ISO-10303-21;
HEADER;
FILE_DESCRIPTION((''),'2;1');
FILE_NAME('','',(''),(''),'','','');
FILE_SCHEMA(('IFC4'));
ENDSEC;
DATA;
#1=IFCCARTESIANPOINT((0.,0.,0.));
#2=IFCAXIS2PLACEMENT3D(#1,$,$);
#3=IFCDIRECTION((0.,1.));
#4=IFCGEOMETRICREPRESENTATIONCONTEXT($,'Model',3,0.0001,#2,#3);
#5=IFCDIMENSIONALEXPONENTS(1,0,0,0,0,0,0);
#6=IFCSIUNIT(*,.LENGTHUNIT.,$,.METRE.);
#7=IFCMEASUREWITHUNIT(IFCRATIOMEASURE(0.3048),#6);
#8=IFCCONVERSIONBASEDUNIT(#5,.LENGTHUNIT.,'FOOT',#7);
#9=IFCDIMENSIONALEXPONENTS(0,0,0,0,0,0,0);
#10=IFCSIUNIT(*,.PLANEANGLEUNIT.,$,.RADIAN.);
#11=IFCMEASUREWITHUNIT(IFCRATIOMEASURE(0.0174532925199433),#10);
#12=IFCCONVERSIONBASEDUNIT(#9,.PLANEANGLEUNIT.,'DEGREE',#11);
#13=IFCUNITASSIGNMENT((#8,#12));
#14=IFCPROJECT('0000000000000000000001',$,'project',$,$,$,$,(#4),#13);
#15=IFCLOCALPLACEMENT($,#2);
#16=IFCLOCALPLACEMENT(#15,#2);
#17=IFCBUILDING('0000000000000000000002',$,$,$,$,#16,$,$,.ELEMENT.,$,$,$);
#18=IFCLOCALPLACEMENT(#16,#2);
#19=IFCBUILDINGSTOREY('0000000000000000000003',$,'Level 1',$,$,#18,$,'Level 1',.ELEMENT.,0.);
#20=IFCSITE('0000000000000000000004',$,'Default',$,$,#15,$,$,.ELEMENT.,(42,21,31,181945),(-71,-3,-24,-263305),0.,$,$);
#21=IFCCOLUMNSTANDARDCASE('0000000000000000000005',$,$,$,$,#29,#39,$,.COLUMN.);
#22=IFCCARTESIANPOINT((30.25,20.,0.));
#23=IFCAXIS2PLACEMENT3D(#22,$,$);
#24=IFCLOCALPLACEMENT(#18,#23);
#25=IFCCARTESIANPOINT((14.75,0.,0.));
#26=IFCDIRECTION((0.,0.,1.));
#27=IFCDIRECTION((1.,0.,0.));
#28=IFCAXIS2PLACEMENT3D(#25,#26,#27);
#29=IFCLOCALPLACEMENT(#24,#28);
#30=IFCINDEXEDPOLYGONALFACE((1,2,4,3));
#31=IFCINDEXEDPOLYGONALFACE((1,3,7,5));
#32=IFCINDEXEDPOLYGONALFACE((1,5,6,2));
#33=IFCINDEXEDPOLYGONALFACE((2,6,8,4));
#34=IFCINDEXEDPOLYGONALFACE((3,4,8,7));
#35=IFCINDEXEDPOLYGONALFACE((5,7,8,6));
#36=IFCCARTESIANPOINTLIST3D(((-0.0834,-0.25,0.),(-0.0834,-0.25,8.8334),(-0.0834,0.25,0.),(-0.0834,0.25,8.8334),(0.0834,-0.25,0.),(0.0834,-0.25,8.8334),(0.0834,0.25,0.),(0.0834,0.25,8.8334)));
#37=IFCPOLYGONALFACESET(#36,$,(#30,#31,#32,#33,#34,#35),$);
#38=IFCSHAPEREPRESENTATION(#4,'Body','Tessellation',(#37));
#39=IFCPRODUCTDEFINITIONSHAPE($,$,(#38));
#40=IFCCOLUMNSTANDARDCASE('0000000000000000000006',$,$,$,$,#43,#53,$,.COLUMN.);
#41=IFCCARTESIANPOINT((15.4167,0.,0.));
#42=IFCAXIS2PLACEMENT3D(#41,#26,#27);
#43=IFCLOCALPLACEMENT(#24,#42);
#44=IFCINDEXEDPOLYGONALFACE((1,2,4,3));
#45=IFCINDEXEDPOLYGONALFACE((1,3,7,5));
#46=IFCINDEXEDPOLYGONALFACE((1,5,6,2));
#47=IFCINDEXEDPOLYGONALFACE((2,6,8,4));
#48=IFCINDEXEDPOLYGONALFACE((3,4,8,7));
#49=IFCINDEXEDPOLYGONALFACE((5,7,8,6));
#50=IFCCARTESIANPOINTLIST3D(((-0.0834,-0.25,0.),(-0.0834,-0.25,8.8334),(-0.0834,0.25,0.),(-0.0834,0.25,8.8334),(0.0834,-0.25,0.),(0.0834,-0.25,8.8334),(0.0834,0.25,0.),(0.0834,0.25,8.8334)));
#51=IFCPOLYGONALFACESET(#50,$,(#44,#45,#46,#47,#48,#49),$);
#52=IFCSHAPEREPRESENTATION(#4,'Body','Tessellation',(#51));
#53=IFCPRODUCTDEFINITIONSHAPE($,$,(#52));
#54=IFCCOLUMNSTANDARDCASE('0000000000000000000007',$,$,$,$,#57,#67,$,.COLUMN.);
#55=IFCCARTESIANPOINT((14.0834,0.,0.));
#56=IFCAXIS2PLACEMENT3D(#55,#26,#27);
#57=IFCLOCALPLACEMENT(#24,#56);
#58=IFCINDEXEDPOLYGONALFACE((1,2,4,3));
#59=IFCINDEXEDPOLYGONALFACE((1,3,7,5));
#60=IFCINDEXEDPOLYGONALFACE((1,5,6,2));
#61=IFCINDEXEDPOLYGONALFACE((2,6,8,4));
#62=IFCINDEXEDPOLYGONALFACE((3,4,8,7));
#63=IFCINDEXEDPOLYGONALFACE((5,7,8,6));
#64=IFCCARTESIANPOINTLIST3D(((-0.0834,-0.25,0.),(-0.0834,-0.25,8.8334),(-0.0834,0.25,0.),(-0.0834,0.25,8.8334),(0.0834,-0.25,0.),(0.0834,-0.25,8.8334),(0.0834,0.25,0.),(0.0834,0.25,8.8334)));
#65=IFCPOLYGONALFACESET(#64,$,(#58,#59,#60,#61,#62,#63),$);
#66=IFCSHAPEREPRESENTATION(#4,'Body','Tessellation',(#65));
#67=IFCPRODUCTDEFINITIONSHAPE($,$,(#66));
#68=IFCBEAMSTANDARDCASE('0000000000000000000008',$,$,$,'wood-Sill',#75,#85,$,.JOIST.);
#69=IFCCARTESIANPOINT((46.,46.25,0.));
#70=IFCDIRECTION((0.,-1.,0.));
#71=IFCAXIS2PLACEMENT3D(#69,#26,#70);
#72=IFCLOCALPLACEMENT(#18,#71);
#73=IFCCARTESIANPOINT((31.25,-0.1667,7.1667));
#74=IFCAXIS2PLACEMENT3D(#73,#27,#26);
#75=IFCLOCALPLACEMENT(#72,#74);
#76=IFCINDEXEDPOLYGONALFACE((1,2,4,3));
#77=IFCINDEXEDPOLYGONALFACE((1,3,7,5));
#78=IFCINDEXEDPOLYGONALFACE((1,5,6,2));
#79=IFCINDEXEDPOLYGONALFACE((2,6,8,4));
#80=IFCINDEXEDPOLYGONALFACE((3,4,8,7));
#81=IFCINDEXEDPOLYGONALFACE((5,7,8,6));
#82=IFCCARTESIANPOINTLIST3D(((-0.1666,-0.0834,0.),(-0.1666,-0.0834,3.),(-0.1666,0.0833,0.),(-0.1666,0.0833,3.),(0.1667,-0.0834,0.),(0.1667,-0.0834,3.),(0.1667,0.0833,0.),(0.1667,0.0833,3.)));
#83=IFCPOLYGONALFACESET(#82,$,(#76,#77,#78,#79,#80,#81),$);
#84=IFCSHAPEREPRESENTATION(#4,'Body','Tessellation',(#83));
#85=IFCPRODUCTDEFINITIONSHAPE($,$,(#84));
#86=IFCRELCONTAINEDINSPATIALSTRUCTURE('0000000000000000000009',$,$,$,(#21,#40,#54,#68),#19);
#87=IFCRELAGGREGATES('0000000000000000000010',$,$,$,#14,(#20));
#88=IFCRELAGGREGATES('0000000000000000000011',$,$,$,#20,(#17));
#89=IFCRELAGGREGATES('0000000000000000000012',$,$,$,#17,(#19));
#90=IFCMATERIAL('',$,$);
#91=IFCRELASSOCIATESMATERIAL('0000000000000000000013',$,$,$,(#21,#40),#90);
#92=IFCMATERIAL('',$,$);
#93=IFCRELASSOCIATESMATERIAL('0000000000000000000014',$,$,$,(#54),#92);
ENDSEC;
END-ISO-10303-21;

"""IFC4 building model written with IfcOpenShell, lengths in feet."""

from ifc_helpers import new_model, entity, si_unit, converted_unit, direction, frame, origin, origin_with_axes, place, context, project, spatial, rectangle, extrude, material, element, save


model = new_model("IFC4")

# Units and contexts
model_context = context("Model", 3, precision=0.0001, world=origin(), true_north=direction((0.0, 1.0)))
ifc_project = project(units=[converted_unit("LENGTHUNIT", "FOOT", entity("IfcRatioMeasure", 0.3048), si_unit("LENGTHUNIT", "METRE"), dimensions=[1, 0, 0, 0, 0, 0, 0]), converted_unit("PLANEANGLEUNIT", "DEGREE", entity("IfcRatioMeasure", 0.0174532925199433), si_unit("PLANEANGLEUNIT", "RADIAN"), dimensions=[0, 0, 0, 0, 0, 0, 0])], contexts=[model_context])

# Site, building, storey
site_placement = place(None, origin())
site = spatial("IfcSite", under=ifc_project, at=site_placement, Name="Default", CompositionType="ELEMENT", RefLatitude=(42, 21, 31, 181945), RefLongitude=(-71, -3, -24, -263305), RefElevation=0.0)
building_placement = place(site_placement, origin())
building = spatial("IfcBuilding", under=site, at=building_placement, CompositionType="ELEMENT")
storey_placement = place(building_placement, origin())
storey = spatial("IfcBuildingStorey", under=building, at=storey_placement, Name="Level 1", LongName="Level 1", CompositionType="ELEMENT", Elevation=0.0)

# Columns
placement_1 = place(storey_placement, frame((46.0, 46.25, 0.0), z_axis=(0.0, 0.0, 1.0), x_axis=(0.0, -1.0, 0.0)))
ifc_material_1 = material(Name="")
placement_2 = place(storey_placement, frame((30.25, 20.0, 0.0)))
for number, where, z_axis, x_axis in (
    (1, (14.75, 0.0, 0.0), (0.0, 0.0, 1.0), (1.0, 0.0, 0.0)),
    (2, (15.4167, 0.0, 0.0), (0.0, 0.0, 1.0), (1.0, 0.0, 0.0)),
):
    element("IfcColumnStandardCase", number, at=place(placement_2, frame(where, z_axis=z_axis, x_axis=x_axis)), inside=storey, material=ifc_material_1, PredefinedType="COLUMN", context=model_context, shape_type="SweptSolid", body=[
        extrude(rectangle(XDim=0.1667, YDim=0.5), origin(), (0.0, 0.0, 1.0), 8.8334),
    ])
ifc_material_2 = material(Name="")
for number, where, z_axis, x_axis in (
    (3, (14.0834, 0.0, 0.0), (0.0, 0.0, 1.0), (1.0, 0.0, 0.0)),
):
    element("IfcColumnStandardCase", number, at=place(placement_2, frame(where, z_axis=z_axis, x_axis=x_axis)), inside=storey, material=ifc_material_2, PredefinedType="COLUMN", context=model_context, shape_type="SweptSolid", body=[
        extrude(rectangle(XDim=0.1667, YDim=0.5), origin(), (0.0, 0.0, 1.0), 8.8334),
    ])

# Beam
for number, where, z_axis, x_axis in (
    (4, (31.25, -0.1667, 7.1667), (1.0, 0.0, 0.0), (0.0, 0.0, 1.0)),
):
    element("IfcBeamStandardCase", number, at=place(placement_1, frame(where, z_axis=z_axis, x_axis=x_axis)), inside=storey, ObjectType="wood-Sill", PredefinedType="JOIST", context=model_context, shape_type="SweptSolid", body=[
        extrude(rectangle(XDim=0.3333, YDim=0.1667), origin_with_axes(), (0.0, 0.0, 1.0), 3.0),
    ])

save(model, "model.ifc")
